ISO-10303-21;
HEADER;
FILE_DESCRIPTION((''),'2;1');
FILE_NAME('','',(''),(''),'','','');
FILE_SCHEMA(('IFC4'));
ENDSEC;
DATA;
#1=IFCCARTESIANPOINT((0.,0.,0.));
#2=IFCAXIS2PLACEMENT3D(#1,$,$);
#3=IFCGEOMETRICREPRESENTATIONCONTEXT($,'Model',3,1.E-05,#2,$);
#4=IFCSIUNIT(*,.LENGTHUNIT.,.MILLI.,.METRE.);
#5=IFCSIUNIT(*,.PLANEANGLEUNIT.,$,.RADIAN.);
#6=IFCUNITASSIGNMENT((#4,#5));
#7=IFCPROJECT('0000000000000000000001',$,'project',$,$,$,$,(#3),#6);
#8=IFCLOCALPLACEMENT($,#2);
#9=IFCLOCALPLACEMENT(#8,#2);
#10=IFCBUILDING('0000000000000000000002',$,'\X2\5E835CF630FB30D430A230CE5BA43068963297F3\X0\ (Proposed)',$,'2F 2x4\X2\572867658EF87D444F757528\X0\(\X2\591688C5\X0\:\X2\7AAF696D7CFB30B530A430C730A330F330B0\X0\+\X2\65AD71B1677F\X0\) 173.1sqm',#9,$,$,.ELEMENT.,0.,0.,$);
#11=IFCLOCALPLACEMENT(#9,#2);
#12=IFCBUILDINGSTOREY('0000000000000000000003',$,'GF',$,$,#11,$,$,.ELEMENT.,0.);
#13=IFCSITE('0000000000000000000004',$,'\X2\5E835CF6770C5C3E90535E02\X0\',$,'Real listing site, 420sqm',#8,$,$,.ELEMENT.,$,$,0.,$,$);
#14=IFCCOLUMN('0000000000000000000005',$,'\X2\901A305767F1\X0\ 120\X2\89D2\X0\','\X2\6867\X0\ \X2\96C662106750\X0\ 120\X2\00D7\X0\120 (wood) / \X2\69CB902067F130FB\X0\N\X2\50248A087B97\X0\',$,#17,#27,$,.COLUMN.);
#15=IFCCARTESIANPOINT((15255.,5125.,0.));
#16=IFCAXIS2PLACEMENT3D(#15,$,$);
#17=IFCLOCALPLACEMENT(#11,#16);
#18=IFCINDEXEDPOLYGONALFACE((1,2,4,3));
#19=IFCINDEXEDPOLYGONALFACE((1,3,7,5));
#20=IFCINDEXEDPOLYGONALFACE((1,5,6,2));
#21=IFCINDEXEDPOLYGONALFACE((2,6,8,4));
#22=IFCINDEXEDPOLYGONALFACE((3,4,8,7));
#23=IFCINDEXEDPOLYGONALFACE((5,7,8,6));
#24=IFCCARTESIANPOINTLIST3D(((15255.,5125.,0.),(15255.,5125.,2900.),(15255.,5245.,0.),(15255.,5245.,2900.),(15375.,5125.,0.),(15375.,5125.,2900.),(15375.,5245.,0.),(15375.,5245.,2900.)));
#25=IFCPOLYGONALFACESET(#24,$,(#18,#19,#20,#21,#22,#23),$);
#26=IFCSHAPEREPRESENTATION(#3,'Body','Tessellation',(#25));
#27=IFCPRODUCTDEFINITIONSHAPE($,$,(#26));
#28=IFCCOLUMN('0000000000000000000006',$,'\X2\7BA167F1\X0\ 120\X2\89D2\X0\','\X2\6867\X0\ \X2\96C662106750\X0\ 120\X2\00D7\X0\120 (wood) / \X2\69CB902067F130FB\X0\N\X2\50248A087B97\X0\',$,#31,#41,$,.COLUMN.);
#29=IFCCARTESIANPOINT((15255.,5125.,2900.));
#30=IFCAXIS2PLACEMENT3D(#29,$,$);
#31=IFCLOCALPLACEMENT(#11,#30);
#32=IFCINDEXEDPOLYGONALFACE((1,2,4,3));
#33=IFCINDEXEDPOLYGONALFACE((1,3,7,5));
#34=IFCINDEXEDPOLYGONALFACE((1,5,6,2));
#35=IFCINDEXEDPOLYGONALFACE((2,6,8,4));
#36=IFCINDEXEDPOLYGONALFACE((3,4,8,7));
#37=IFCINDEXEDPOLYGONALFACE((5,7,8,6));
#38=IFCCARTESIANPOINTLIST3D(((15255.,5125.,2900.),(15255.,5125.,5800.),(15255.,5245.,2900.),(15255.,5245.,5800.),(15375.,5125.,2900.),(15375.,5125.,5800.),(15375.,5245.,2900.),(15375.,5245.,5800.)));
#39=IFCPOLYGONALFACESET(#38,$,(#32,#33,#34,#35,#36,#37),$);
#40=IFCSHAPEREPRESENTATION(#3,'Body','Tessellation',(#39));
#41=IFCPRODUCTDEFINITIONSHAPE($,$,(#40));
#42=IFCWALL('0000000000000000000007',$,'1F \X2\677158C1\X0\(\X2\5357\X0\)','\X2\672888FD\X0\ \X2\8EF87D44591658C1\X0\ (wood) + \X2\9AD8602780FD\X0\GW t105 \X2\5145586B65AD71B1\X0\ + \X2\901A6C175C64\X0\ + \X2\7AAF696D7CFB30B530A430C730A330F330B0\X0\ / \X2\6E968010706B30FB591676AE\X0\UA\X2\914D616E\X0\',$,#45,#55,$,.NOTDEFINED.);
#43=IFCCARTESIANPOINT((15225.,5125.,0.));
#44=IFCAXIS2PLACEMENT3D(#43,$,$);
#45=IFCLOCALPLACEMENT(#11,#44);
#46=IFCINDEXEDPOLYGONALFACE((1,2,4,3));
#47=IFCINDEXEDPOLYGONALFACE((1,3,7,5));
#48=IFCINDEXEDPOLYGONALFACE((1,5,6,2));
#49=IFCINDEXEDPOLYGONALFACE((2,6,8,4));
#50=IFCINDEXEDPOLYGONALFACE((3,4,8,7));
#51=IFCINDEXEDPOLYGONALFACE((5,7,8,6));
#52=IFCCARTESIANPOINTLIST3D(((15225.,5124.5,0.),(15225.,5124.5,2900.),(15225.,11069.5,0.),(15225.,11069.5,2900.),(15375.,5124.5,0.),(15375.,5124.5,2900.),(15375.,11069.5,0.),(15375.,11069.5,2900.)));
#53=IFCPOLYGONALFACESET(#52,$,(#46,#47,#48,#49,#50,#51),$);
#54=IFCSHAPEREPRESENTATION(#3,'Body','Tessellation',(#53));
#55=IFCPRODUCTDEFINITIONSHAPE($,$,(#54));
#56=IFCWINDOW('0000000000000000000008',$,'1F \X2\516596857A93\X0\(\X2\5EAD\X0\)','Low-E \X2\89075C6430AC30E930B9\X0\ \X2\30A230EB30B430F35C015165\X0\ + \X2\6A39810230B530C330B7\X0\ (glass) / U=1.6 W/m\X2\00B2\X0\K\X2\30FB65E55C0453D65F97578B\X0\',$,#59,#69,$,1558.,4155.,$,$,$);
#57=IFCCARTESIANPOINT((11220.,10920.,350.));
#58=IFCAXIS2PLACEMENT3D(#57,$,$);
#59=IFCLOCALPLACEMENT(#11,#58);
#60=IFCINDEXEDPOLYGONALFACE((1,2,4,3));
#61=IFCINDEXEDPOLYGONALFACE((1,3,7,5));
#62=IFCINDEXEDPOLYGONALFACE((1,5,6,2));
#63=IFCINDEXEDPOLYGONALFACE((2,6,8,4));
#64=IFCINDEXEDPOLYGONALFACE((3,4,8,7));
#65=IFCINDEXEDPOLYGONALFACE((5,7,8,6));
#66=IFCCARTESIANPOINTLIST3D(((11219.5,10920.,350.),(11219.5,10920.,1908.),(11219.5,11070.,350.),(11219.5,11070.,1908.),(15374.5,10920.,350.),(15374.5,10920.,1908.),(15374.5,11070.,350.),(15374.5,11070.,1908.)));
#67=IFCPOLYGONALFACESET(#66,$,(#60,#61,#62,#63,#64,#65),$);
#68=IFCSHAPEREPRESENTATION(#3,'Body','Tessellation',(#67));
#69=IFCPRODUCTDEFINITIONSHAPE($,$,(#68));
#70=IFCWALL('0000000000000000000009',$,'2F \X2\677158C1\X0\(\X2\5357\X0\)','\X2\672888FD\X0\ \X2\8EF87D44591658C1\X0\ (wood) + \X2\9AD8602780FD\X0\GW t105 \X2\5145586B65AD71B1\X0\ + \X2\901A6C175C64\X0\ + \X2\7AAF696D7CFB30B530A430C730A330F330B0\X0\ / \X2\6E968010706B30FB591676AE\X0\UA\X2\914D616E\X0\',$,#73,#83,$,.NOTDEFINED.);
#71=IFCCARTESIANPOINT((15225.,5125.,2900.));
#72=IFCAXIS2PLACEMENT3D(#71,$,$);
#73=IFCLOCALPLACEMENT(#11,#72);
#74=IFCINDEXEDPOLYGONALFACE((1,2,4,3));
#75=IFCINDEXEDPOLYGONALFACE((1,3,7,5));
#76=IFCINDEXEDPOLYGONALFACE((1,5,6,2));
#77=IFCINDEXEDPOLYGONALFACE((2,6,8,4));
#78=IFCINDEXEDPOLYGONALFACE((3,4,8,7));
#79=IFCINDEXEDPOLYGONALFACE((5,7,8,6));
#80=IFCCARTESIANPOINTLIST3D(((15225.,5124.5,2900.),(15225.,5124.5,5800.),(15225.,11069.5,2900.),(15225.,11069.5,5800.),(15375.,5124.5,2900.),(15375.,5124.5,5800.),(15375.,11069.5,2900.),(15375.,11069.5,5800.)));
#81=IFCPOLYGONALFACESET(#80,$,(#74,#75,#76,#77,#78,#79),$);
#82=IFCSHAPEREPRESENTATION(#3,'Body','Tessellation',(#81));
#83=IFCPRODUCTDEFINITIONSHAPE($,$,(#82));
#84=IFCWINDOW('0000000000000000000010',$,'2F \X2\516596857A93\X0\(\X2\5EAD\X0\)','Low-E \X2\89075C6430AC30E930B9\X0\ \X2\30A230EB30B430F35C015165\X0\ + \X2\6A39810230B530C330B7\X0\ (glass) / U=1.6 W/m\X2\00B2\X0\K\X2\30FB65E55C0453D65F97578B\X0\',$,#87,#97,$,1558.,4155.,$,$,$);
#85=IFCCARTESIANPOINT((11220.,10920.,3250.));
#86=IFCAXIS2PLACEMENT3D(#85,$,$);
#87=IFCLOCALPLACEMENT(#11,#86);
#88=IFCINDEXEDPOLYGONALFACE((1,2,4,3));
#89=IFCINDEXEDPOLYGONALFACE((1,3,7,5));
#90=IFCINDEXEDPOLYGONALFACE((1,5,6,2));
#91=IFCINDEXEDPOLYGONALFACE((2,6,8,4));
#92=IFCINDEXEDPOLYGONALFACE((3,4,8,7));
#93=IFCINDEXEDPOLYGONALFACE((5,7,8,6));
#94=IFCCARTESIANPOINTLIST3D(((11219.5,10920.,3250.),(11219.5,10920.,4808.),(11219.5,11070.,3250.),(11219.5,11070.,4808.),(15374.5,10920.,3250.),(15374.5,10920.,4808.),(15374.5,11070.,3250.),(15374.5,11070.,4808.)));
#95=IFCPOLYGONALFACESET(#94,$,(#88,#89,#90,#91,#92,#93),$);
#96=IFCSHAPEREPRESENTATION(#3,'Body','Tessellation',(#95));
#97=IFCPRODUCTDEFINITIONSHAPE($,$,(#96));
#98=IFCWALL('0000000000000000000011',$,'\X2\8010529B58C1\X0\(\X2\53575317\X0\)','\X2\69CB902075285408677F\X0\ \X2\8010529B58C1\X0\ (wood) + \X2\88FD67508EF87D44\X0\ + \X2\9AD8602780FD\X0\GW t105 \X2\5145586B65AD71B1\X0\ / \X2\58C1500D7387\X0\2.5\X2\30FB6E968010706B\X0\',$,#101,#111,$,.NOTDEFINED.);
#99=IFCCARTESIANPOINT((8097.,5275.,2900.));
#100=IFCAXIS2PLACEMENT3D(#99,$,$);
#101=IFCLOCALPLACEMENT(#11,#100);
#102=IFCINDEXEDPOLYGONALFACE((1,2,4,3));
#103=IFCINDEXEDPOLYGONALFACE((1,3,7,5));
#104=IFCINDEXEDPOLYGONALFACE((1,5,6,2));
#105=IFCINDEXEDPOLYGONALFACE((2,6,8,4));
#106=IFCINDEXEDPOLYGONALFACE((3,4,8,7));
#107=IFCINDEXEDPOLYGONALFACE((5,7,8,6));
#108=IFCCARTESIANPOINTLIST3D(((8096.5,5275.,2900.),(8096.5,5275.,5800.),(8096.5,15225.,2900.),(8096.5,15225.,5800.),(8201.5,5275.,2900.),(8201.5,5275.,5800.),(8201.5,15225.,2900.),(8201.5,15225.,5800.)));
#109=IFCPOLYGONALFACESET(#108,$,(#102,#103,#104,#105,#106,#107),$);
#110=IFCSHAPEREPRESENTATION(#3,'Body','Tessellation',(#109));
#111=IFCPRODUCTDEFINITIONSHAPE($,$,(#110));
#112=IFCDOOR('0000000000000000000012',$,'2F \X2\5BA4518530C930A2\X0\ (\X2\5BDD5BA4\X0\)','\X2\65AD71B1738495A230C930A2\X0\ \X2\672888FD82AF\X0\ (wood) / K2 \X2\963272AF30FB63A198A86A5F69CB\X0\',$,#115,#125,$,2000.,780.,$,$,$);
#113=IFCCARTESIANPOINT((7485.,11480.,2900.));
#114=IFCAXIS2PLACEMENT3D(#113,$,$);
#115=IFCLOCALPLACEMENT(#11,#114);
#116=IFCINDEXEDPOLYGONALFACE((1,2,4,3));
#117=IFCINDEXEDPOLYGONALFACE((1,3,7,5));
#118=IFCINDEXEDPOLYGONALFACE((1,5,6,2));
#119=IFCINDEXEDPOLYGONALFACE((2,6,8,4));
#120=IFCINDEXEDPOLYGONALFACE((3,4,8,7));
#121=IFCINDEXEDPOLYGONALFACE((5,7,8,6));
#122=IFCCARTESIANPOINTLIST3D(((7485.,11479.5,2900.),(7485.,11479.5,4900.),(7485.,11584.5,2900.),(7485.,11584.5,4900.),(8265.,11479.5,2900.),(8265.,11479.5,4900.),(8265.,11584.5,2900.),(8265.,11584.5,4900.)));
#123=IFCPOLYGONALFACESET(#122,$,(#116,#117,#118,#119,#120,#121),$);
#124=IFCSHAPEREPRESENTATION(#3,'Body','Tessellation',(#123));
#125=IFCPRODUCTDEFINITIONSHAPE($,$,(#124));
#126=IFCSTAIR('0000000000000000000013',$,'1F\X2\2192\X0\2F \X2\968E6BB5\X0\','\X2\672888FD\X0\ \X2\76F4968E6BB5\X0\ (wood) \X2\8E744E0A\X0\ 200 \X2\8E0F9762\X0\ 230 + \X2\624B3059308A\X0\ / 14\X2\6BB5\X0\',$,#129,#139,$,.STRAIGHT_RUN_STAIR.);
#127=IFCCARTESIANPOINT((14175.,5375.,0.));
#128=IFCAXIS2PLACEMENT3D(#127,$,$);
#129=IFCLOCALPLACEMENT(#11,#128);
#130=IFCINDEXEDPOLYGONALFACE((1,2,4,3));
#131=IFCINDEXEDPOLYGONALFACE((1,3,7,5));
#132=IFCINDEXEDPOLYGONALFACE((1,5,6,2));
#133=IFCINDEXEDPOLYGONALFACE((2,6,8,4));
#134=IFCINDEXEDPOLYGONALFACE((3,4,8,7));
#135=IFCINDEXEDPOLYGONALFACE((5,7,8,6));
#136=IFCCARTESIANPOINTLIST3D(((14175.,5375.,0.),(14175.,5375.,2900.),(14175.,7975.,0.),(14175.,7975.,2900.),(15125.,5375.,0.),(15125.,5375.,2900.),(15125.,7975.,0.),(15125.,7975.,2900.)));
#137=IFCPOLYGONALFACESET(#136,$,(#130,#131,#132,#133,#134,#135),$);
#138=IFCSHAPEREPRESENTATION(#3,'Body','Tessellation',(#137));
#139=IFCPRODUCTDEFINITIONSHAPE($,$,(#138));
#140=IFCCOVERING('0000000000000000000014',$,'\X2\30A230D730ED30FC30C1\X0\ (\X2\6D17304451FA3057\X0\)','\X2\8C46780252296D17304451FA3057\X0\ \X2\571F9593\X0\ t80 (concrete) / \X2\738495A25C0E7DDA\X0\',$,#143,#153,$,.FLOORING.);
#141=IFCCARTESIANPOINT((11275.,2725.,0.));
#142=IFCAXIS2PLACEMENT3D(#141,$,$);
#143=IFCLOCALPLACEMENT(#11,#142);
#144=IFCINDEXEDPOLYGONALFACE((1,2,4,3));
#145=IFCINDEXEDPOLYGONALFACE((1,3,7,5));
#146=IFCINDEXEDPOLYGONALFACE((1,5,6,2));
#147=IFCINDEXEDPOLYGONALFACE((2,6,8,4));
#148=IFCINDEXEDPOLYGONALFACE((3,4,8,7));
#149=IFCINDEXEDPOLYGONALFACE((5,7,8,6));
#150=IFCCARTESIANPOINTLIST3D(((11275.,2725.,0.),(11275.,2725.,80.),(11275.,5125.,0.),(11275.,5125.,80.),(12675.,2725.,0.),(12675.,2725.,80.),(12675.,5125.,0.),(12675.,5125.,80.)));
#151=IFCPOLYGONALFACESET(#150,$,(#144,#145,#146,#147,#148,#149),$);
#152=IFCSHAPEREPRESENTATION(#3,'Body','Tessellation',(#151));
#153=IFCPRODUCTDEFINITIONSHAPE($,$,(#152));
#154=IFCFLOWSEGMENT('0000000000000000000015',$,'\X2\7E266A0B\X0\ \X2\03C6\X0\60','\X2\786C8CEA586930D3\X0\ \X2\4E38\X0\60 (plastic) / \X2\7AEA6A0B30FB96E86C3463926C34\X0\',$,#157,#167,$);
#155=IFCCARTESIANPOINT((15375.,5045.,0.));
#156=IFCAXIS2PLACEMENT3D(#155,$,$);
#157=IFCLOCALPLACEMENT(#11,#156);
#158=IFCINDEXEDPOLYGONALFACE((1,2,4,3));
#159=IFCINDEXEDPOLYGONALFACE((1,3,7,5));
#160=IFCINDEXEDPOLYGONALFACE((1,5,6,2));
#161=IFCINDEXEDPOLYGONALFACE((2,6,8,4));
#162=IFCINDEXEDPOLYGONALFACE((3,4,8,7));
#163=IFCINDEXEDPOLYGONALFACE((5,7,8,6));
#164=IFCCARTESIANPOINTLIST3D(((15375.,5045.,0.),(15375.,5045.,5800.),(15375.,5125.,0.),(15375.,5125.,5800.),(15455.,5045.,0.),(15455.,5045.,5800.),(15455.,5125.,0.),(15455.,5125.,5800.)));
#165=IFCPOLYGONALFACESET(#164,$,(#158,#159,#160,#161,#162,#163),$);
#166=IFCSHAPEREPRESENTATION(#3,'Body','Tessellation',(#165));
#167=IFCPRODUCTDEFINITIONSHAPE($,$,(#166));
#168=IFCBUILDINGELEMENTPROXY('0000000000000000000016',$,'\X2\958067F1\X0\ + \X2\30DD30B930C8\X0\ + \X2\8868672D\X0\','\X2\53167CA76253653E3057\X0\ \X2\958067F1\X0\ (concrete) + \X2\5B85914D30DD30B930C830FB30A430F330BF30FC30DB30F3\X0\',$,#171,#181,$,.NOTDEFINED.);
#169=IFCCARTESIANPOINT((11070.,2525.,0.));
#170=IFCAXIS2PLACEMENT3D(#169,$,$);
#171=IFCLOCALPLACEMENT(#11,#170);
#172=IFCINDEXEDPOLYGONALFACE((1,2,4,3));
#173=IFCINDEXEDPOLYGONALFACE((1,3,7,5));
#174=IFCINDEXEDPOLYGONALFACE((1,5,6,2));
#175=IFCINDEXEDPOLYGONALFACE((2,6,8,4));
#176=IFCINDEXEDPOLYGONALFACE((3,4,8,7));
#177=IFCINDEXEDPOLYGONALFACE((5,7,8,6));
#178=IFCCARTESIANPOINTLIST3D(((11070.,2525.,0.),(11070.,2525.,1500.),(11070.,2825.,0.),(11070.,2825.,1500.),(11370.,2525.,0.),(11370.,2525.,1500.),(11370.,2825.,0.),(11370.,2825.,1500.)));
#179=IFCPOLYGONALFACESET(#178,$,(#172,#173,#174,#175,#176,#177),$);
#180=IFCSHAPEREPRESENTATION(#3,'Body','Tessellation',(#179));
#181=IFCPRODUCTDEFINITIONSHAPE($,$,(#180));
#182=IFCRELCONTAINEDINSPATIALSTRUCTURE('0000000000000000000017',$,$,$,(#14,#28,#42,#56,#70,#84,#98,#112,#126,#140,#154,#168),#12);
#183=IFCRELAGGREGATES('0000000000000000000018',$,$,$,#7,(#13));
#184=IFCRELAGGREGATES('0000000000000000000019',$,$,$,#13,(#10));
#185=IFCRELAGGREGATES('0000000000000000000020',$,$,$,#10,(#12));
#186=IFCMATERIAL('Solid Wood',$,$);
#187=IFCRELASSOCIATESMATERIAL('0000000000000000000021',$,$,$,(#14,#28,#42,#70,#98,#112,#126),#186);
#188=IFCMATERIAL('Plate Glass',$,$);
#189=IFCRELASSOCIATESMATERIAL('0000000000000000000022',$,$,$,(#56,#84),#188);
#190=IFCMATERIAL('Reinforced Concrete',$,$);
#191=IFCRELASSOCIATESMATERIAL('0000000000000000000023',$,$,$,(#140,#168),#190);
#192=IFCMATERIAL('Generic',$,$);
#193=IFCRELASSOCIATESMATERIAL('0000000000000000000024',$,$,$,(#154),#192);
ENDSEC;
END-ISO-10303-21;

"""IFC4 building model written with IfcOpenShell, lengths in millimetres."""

from ifc_helpers import new_model, si_unit, frame, frame_2d, origin, place, context, project, spatial, rectangle, extrude, material, element, fill, save


model = new_model("IFC4")

# Units and contexts
model_context = context("Model", 3, precision=1e-05, world=origin())
ifc_project = project(units=[si_unit("LENGTHUNIT", "METRE", prefix="MILLI"), si_unit("PLANEANGLEUNIT", "RADIAN")], contexts=[model_context])

# Site, building, storey
site_placement = place(None, origin())
site = spatial("IfcSite", under=ifc_project, at=site_placement, Name="広島県尾道市", ObjectType="Real listing site, 420sqm", CompositionType="ELEMENT", RefElevation=0.0)
building_placement = place(site_placement, origin())
building = spatial("IfcBuilding", under=site, at=building_placement, Name="広島・ピアノ室と防音 (Proposed)", ObjectType="2F 2x4在来軸組併用(外装:窯業系サイディング+断熱板) 173.1sqm", CompositionType="ELEMENT", ElevationOfRefHeight=0.0, ElevationOfTerrain=0.0)
storey_placement = place(building_placement, origin())
storey = spatial("IfcBuildingStorey", under=building, at=storey_placement, Name="GF", CompositionType="ELEMENT", Elevation=0.0)

# Columns
ifc_material_1 = material(Name="Solid Wood")
column_1_placement = place(storey_placement, frame((15255.0, 5125.0, 0.0)))
element("IfcColumn", 1, at=column_1_placement, inside=storey, material=ifc_material_1, Name="通し柱 120角", Description="桧 集成材 120×120 (wood) / 構造柱・N値計算", PredefinedType="COLUMN", context=model_context, shape_type="SweptSolid", body=[
    extrude(rectangle(XDim=120.0, YDim=120.0, at=frame_2d((60.0, 60.0))), frame((15255.0, 5125.0, 0.0)), (0.0, 0.0, 1.0), 2900.0),
])
column_2_placement = place(storey_placement, frame((15255.0, 5125.0, 2900.0)))
element("IfcColumn", 2, at=column_2_placement, inside=storey, material=ifc_material_1, Name="管柱 120角", Description="桧 集成材 120×120 (wood) / 構造柱・N値計算", PredefinedType="COLUMN", context=model_context, shape_type="SweptSolid", body=[
    extrude(rectangle(XDim=120.0, YDim=120.0, at=frame_2d((60.0, 60.0))), frame((15255.0, 5125.0, 2900.0)), (0.0, 0.0, 1.0), 2900.0),
])

# Wall, opening, window
wall_1_placement = place(storey_placement, frame((15225.0, 5125.0, 0.0)))
wall_1 = element("IfcWall", 3, at=wall_1_placement, inside=storey, material=ifc_material_1, Name="1F 東壁(南)", Description="木製 軸組外壁 (wood) + 高性能GW t105 充填断熱 + 通気層 + 窯業系サイディング / 準耐火・外皮UA配慮", PredefinedType="NOTDEFINED", context=model_context, shape_type="SweptSolid", body=[
    extrude(rectangle(XDim=150.0, YDim=5945.0, at=frame_2d((75.0, 2972.0))), frame((15225.0, 5125.0, 0.0)), (0.0, 0.0, 1.0), 2900.0),
])
opening_1_placement = place(storey_placement, frame((11220.0, 10920.0, 350.0)))
opening_1 = element("IfcOpeningElement", 4, at=opening_1_placement, cuts=wall_1, PredefinedType="NOTDEFINED", context=model_context, shape_type="SweptSolid", body=[
    extrude(rectangle(XDim=4155.0, YDim=150.0, at=frame_2d((2077.0, 75.0))), frame((11220.0, 10920.0, 350.0)), (0.0, 0.0, 1.0), 1558.0),
])
ifc_material_2 = material(Name="Plate Glass")
window_1_placement = place(storey_placement, frame((11220.0, 10920.0, 350.0)))
window_1 = element("IfcWindow", 5, at=window_1_placement, inside=storey, material=ifc_material_2, Name="1F 入隅窓(庭)", Description="Low-E 複層ガラス アルゴン封入 + 樹脂サッシ (glass) / U=1.6 W/m²K・日射取得型", OverallHeight=1558.0, OverallWidth=4155.0, context=model_context, shape_type="SweptSolid", body=[
    extrude(rectangle(XDim=4155.0, YDim=150.0, at=frame_2d((2077.0, 75.0))), frame((11220.0, 10920.0, 350.0)), (0.0, 0.0, 1.0), 1558.0),
])
fill(opening_1, window_1)

# Wall, opening, window
wall_2_placement = place(storey_placement, frame((15225.0, 5125.0, 2900.0)))
wall_2 = element("IfcWall", 6, at=wall_2_placement, inside=storey, material=ifc_material_1, Name="2F 東壁(南)", Description="木製 軸組外壁 (wood) + 高性能GW t105 充填断熱 + 通気層 + 窯業系サイディング / 準耐火・外皮UA配慮", PredefinedType="NOTDEFINED", context=model_context, shape_type="SweptSolid", body=[
    extrude(rectangle(XDim=150.0, YDim=5945.0, at=frame_2d((75.0, 2972.0))), frame((15225.0, 5125.0, 2900.0)), (0.0, 0.0, 1.0), 2900.0),
])
opening_2_placement = place(storey_placement, frame((11220.0, 10920.0, 3250.0)))
opening_2 = element("IfcOpeningElement", 7, at=opening_2_placement, cuts=wall_2, PredefinedType="NOTDEFINED", context=model_context, shape_type="SweptSolid", body=[
    extrude(rectangle(XDim=4155.0, YDim=150.0, at=frame_2d((2077.0, 75.0))), frame((11220.0, 10920.0, 3250.0)), (0.0, 0.0, 1.0), 1558.0),
])
window_2_placement = place(storey_placement, frame((11220.0, 10920.0, 3250.0)))
window_2 = element("IfcWindow", 8, at=window_2_placement, inside=storey, material=ifc_material_2, Name="2F 入隅窓(庭)", Description="Low-E 複層ガラス アルゴン封入 + 樹脂サッシ (glass) / U=1.6 W/m²K・日射取得型", OverallHeight=1558.0, OverallWidth=4155.0, context=model_context, shape_type="SweptSolid", body=[
    extrude(rectangle(XDim=4155.0, YDim=150.0, at=frame_2d((2077.0, 75.0))), frame((11220.0, 10920.0, 3250.0)), (0.0, 0.0, 1.0), 1558.0),
])
fill(opening_2, window_2)

# Wall, opening, door
wall_3_placement = place(storey_placement, frame((8097.0, 5275.0, 2900.0)))
wall_3 = element("IfcWall", 9, at=wall_3_placement, inside=storey, material=ifc_material_1, Name="耐力壁(南北)", Description="構造用合板 耐力壁 (wood) + 製材軸組 + 高性能GW t105 充填断熱 / 壁倍率2.5・準耐火", PredefinedType="NOTDEFINED", context=model_context, shape_type="SweptSolid", body=[
    extrude(rectangle(XDim=105.0, YDim=9950.0, at=frame_2d((52.0, 4975.0))), frame((8097.0, 5275.0, 2900.0)), (0.0, 0.0, 1.0), 2900.0),
])
opening_3_placement = place(storey_placement, frame((7485.0, 11480.0, 2900.0)))
opening_3 = element("IfcOpeningElement", 10, at=opening_3_placement, cuts=wall_3, PredefinedType="NOTDEFINED", context=model_context, shape_type="SweptSolid", body=[
    extrude(rectangle(XDim=780.0, YDim=105.0, at=frame_2d((390.0, 52.0))), frame((7485.0, 11480.0, 2900.0)), (0.0, 0.0, 1.0), 2000.0),
])
door_1_placement = place(storey_placement, frame((7485.0, 11480.0, 2900.0)))
door_1 = element("IfcDoor", 11, at=door_1_placement, inside=storey, material=ifc_material_1, Name="2F 室内ドア (寝室)", Description="断熱玄関ドア 木製芯 (wood) / K2 防犯・採風機構", OverallHeight=2000.0, OverallWidth=780.0, context=model_context, shape_type="SweptSolid", body=[
    extrude(rectangle(XDim=780.0, YDim=105.0, at=frame_2d((390.0, 52.0))), frame((7485.0, 11480.0, 2900.0)), (0.0, 0.0, 1.0), 2000.0),
])
fill(opening_3, door_1)

# Stair
stair_placement = place(storey_placement, frame((14175.0, 5375.0, 0.0)))
element("IfcStair", 12, at=stair_placement, inside=storey, material=ifc_material_1, Name="1F→2F 階段", Description="木製 直階段 (wood) 蹴上 200 踏面 230 + 手すり / 14段", PredefinedType="STRAIGHT_RUN_STAIR", context=model_context, shape_type="SweptSolid", body=[
    extrude(rectangle(XDim=950.0, YDim=2600.0, at=frame_2d((475.0, 1300.0))), frame((14175.0, 5375.0, 0.0)), (0.0, 0.0, 1.0), 2900.0),
])

# Covering
ifc_material_3 = material(Name="Reinforced Concrete")
covering_placement = place(storey_placement, frame((11275.0, 2725.0, 0.0)))
element("IfcCovering", 13, at=covering_placement, inside=storey, material=ifc_material_3, Name="アプローチ (洗い出し)", Description="豆砂利洗い出し 土間 t80 (concrete) / 玄関導線", PredefinedType="FLOORING", context=model_context, shape_type="SweptSolid", body=[
    extrude(rectangle(XDim=1400.0, YDim=2400.0, at=frame_2d((700.0, 1200.0))), frame((11275.0, 2725.0, 0.0)), (0.0, 0.0, 1.0), 80.0),
])

# Flow segment
ifc_material_4 = material(Name="Generic")
flow_segment_placement = place(storey_placement, frame((15375.0, 5045.0, 0.0)))
element("IfcFlowSegment", 14, at=flow_segment_placement, inside=storey, material=ifc_material_4, Name="縦樋 φ60", Description="硬質塩ビ 丸60 (plastic) / 竪樋・雨水排水", context=model_context, shape_type="SweptSolid", body=[
    extrude(rectangle(XDim=80.0, YDim=80.0, at=frame_2d((40.0, 40.0))), frame((15375.0, 5045.0, 0.0)), (0.0, 0.0, 1.0), 5800.0),
])

# Building element proxy
proxy_placement = place(storey_placement, frame((11070.0, 2525.0, 0.0)))
element("IfcBuildingElementProxy", 15, at=proxy_placement, inside=storey, material=ifc_material_3, Name="門柱 + ポスト + 表札", Description="化粧打放し 門柱 (concrete) + 宅配ポスト・インターホン", PredefinedType="NOTDEFINED", context=model_context, shape_type="SweptSolid", body=[
    extrude(rectangle(XDim=300.0, YDim=300.0, at=frame_2d((150.0, 150.0))), frame((11070.0, 2525.0, 0.0)), (0.0, 0.0, 1.0), 1500.0),
])

save(model, "model.ifc")
